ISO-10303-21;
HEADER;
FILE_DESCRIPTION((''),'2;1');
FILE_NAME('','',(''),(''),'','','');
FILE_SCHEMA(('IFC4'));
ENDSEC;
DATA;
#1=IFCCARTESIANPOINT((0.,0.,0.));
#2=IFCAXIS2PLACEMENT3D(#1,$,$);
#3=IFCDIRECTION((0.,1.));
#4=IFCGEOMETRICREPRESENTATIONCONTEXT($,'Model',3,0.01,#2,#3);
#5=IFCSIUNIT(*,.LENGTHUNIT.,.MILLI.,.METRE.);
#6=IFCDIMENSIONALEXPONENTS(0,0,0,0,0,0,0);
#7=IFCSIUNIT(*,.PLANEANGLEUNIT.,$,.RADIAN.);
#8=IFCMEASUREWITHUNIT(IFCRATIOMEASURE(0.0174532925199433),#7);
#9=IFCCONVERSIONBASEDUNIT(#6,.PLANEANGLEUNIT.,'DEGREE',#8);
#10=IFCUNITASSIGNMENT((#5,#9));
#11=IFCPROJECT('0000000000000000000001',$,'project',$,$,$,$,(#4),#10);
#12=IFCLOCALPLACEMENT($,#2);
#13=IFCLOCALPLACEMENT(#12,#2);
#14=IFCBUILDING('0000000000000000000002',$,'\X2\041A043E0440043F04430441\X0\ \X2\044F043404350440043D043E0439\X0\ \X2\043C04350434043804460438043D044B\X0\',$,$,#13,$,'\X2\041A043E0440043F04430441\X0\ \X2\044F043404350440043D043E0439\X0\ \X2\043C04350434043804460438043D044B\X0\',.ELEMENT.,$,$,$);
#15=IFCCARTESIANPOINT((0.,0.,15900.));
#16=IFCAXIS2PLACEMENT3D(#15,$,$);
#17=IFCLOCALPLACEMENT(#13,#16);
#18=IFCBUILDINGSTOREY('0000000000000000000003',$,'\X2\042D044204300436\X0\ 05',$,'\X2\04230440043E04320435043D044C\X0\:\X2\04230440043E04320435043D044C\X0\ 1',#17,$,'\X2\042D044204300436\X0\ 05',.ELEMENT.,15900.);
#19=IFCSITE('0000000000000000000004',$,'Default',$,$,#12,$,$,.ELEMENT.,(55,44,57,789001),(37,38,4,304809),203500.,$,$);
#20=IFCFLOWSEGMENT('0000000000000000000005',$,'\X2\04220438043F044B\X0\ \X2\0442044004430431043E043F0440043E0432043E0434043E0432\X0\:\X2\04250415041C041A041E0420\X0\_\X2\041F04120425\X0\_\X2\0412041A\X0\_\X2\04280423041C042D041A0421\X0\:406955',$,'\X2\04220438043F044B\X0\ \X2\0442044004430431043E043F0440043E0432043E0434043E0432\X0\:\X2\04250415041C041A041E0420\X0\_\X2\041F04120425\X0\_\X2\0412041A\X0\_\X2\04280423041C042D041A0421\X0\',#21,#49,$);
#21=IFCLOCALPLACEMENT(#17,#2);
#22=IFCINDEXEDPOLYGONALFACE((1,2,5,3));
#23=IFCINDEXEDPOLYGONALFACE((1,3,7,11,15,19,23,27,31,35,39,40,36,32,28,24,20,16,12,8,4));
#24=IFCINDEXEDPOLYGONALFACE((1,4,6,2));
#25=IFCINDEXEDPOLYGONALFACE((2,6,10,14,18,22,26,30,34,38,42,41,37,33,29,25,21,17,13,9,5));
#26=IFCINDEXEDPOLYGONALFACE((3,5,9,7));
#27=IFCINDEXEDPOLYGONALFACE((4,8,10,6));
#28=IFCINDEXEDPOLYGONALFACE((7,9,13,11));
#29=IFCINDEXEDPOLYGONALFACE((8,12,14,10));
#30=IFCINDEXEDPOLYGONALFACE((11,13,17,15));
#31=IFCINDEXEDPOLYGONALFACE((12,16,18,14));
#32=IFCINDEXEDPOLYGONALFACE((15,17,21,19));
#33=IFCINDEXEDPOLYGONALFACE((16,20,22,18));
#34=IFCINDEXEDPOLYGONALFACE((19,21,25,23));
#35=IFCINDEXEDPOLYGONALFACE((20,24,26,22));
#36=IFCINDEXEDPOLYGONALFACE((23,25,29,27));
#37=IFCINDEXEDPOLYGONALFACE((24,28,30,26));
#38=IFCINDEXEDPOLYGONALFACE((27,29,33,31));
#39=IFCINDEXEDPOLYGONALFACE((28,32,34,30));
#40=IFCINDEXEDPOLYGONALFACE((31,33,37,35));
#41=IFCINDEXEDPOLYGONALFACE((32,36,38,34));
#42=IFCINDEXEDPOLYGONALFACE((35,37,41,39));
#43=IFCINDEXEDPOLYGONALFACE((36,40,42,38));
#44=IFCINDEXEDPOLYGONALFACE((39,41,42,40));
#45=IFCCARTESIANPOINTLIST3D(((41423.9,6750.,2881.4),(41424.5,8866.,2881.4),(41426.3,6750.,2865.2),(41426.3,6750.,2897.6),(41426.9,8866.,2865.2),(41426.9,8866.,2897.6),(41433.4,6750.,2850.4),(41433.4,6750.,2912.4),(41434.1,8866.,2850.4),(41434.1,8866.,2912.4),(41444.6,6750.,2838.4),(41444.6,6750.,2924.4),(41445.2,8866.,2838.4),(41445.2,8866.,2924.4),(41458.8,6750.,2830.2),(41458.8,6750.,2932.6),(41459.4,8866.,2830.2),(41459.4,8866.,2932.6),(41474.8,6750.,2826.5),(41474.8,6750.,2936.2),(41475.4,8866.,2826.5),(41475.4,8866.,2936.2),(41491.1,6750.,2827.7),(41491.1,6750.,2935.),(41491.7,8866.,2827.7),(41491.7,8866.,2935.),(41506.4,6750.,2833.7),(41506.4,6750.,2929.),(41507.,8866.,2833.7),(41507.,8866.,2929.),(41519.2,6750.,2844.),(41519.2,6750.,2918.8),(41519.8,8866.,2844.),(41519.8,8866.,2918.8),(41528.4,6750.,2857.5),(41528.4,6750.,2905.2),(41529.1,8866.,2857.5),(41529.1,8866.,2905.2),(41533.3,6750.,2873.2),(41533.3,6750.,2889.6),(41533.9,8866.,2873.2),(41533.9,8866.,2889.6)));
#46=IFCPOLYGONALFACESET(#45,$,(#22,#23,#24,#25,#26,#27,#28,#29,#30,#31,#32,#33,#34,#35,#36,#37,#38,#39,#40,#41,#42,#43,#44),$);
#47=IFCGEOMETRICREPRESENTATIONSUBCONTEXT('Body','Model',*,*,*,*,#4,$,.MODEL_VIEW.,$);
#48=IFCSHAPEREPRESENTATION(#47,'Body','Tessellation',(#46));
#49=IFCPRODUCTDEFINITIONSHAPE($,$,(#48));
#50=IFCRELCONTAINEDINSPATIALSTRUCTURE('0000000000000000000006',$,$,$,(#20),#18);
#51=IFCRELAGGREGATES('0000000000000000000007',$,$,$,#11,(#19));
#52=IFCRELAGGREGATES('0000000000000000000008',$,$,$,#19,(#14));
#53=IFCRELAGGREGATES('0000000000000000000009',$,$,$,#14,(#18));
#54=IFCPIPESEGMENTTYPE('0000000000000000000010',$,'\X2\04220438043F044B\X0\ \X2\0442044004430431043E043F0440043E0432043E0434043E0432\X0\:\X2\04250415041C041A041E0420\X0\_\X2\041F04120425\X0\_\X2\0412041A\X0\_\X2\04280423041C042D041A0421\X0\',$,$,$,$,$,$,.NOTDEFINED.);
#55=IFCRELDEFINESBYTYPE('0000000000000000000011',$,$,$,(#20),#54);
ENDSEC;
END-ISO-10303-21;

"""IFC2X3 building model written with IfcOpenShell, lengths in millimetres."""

from ifc_helpers import new_model, entity, si_unit, converted_unit, direction, frame, frame_2d, origin, place, context, subcontext, project, spatial, circle, extrude, type_object, element, save


model = new_model("IFC2X3")

# Units and contexts
model_context = context("Model", 3, precision=0.01, world=origin(), true_north=direction((0.0, 1.0)))
body_context = subcontext(model_context, "Body", "Model", "MODEL_VIEW")
ifc_project = project(units=[si_unit("LENGTHUNIT", "METRE", prefix="MILLI"), converted_unit("PLANEANGLEUNIT", "DEGREE", entity("IfcRatioMeasure", 0.0174532925199433), si_unit("PLANEANGLEUNIT", "RADIAN"), dimensions=[0, 0, 0, 0, 0, 0, 0])], contexts=[model_context])

# Site, building, storey
site_placement = place(None, frame((0.0, 0.0, 0.0)))
site = spatial("IfcSite", under=ifc_project, at=site_placement, Name="Default", CompositionType="ELEMENT", RefLatitude=(55, 44, 57, 789001), RefLongitude=(37, 38, 4, 304809), RefElevation=203500.0)
building_placement = place(site_placement, origin())
building = spatial("IfcBuilding", under=site, at=building_placement, Name="Корпус ядерной медицины", LongName="Корпус ядерной медицины", CompositionType="ELEMENT")
storey_placement = place(building_placement, frame((0.0, 0.0, 15900.0)))
storey = spatial("IfcBuildingStorey", under=building, at=storey_placement, Name="Этаж 05", ObjectType="Уровень:Уровень 1", LongName="Этаж 05", CompositionType="ELEMENT", Elevation=15900.0)

# Flow segment
pipe_segment_type = type_object("IfcPipeSegmentType", Name="Типы трубопроводов:ХЕМКОР_ПВХ_ВК_ШУМЭКС", PredefinedType="NOTDEFINED")
flow_segment_1_placement = place(storey_placement, frame((41422.3, 6750.0, 2824.8)))
element("IfcFlowSegment", 1, at=flow_segment_1_placement, inside=storey, type_object=pipe_segment_type, Name="Типы трубопроводов:ХЕМКОР_ПВХ_ВК_ШУМЭКС:406955", ObjectType="Типы трубопроводов:ХЕМКОР_ПВХ_ВК_ШУМЭКС", context=body_context, shape_type="SweptSolid", body=[
    extrude(circle(Radius=55.0, at=frame_2d((0.0, 0.0), x_axis=(1.0, 0.0))), frame((56.6, 0.0, 56.6), z_axis=(0.000289, 1.0, 0.0), x_axis=(-1.0, 0.000289, 0.0)), (0.0, 0.0, 1.0), 2116.0),
])

save(model, "model.ifc")
